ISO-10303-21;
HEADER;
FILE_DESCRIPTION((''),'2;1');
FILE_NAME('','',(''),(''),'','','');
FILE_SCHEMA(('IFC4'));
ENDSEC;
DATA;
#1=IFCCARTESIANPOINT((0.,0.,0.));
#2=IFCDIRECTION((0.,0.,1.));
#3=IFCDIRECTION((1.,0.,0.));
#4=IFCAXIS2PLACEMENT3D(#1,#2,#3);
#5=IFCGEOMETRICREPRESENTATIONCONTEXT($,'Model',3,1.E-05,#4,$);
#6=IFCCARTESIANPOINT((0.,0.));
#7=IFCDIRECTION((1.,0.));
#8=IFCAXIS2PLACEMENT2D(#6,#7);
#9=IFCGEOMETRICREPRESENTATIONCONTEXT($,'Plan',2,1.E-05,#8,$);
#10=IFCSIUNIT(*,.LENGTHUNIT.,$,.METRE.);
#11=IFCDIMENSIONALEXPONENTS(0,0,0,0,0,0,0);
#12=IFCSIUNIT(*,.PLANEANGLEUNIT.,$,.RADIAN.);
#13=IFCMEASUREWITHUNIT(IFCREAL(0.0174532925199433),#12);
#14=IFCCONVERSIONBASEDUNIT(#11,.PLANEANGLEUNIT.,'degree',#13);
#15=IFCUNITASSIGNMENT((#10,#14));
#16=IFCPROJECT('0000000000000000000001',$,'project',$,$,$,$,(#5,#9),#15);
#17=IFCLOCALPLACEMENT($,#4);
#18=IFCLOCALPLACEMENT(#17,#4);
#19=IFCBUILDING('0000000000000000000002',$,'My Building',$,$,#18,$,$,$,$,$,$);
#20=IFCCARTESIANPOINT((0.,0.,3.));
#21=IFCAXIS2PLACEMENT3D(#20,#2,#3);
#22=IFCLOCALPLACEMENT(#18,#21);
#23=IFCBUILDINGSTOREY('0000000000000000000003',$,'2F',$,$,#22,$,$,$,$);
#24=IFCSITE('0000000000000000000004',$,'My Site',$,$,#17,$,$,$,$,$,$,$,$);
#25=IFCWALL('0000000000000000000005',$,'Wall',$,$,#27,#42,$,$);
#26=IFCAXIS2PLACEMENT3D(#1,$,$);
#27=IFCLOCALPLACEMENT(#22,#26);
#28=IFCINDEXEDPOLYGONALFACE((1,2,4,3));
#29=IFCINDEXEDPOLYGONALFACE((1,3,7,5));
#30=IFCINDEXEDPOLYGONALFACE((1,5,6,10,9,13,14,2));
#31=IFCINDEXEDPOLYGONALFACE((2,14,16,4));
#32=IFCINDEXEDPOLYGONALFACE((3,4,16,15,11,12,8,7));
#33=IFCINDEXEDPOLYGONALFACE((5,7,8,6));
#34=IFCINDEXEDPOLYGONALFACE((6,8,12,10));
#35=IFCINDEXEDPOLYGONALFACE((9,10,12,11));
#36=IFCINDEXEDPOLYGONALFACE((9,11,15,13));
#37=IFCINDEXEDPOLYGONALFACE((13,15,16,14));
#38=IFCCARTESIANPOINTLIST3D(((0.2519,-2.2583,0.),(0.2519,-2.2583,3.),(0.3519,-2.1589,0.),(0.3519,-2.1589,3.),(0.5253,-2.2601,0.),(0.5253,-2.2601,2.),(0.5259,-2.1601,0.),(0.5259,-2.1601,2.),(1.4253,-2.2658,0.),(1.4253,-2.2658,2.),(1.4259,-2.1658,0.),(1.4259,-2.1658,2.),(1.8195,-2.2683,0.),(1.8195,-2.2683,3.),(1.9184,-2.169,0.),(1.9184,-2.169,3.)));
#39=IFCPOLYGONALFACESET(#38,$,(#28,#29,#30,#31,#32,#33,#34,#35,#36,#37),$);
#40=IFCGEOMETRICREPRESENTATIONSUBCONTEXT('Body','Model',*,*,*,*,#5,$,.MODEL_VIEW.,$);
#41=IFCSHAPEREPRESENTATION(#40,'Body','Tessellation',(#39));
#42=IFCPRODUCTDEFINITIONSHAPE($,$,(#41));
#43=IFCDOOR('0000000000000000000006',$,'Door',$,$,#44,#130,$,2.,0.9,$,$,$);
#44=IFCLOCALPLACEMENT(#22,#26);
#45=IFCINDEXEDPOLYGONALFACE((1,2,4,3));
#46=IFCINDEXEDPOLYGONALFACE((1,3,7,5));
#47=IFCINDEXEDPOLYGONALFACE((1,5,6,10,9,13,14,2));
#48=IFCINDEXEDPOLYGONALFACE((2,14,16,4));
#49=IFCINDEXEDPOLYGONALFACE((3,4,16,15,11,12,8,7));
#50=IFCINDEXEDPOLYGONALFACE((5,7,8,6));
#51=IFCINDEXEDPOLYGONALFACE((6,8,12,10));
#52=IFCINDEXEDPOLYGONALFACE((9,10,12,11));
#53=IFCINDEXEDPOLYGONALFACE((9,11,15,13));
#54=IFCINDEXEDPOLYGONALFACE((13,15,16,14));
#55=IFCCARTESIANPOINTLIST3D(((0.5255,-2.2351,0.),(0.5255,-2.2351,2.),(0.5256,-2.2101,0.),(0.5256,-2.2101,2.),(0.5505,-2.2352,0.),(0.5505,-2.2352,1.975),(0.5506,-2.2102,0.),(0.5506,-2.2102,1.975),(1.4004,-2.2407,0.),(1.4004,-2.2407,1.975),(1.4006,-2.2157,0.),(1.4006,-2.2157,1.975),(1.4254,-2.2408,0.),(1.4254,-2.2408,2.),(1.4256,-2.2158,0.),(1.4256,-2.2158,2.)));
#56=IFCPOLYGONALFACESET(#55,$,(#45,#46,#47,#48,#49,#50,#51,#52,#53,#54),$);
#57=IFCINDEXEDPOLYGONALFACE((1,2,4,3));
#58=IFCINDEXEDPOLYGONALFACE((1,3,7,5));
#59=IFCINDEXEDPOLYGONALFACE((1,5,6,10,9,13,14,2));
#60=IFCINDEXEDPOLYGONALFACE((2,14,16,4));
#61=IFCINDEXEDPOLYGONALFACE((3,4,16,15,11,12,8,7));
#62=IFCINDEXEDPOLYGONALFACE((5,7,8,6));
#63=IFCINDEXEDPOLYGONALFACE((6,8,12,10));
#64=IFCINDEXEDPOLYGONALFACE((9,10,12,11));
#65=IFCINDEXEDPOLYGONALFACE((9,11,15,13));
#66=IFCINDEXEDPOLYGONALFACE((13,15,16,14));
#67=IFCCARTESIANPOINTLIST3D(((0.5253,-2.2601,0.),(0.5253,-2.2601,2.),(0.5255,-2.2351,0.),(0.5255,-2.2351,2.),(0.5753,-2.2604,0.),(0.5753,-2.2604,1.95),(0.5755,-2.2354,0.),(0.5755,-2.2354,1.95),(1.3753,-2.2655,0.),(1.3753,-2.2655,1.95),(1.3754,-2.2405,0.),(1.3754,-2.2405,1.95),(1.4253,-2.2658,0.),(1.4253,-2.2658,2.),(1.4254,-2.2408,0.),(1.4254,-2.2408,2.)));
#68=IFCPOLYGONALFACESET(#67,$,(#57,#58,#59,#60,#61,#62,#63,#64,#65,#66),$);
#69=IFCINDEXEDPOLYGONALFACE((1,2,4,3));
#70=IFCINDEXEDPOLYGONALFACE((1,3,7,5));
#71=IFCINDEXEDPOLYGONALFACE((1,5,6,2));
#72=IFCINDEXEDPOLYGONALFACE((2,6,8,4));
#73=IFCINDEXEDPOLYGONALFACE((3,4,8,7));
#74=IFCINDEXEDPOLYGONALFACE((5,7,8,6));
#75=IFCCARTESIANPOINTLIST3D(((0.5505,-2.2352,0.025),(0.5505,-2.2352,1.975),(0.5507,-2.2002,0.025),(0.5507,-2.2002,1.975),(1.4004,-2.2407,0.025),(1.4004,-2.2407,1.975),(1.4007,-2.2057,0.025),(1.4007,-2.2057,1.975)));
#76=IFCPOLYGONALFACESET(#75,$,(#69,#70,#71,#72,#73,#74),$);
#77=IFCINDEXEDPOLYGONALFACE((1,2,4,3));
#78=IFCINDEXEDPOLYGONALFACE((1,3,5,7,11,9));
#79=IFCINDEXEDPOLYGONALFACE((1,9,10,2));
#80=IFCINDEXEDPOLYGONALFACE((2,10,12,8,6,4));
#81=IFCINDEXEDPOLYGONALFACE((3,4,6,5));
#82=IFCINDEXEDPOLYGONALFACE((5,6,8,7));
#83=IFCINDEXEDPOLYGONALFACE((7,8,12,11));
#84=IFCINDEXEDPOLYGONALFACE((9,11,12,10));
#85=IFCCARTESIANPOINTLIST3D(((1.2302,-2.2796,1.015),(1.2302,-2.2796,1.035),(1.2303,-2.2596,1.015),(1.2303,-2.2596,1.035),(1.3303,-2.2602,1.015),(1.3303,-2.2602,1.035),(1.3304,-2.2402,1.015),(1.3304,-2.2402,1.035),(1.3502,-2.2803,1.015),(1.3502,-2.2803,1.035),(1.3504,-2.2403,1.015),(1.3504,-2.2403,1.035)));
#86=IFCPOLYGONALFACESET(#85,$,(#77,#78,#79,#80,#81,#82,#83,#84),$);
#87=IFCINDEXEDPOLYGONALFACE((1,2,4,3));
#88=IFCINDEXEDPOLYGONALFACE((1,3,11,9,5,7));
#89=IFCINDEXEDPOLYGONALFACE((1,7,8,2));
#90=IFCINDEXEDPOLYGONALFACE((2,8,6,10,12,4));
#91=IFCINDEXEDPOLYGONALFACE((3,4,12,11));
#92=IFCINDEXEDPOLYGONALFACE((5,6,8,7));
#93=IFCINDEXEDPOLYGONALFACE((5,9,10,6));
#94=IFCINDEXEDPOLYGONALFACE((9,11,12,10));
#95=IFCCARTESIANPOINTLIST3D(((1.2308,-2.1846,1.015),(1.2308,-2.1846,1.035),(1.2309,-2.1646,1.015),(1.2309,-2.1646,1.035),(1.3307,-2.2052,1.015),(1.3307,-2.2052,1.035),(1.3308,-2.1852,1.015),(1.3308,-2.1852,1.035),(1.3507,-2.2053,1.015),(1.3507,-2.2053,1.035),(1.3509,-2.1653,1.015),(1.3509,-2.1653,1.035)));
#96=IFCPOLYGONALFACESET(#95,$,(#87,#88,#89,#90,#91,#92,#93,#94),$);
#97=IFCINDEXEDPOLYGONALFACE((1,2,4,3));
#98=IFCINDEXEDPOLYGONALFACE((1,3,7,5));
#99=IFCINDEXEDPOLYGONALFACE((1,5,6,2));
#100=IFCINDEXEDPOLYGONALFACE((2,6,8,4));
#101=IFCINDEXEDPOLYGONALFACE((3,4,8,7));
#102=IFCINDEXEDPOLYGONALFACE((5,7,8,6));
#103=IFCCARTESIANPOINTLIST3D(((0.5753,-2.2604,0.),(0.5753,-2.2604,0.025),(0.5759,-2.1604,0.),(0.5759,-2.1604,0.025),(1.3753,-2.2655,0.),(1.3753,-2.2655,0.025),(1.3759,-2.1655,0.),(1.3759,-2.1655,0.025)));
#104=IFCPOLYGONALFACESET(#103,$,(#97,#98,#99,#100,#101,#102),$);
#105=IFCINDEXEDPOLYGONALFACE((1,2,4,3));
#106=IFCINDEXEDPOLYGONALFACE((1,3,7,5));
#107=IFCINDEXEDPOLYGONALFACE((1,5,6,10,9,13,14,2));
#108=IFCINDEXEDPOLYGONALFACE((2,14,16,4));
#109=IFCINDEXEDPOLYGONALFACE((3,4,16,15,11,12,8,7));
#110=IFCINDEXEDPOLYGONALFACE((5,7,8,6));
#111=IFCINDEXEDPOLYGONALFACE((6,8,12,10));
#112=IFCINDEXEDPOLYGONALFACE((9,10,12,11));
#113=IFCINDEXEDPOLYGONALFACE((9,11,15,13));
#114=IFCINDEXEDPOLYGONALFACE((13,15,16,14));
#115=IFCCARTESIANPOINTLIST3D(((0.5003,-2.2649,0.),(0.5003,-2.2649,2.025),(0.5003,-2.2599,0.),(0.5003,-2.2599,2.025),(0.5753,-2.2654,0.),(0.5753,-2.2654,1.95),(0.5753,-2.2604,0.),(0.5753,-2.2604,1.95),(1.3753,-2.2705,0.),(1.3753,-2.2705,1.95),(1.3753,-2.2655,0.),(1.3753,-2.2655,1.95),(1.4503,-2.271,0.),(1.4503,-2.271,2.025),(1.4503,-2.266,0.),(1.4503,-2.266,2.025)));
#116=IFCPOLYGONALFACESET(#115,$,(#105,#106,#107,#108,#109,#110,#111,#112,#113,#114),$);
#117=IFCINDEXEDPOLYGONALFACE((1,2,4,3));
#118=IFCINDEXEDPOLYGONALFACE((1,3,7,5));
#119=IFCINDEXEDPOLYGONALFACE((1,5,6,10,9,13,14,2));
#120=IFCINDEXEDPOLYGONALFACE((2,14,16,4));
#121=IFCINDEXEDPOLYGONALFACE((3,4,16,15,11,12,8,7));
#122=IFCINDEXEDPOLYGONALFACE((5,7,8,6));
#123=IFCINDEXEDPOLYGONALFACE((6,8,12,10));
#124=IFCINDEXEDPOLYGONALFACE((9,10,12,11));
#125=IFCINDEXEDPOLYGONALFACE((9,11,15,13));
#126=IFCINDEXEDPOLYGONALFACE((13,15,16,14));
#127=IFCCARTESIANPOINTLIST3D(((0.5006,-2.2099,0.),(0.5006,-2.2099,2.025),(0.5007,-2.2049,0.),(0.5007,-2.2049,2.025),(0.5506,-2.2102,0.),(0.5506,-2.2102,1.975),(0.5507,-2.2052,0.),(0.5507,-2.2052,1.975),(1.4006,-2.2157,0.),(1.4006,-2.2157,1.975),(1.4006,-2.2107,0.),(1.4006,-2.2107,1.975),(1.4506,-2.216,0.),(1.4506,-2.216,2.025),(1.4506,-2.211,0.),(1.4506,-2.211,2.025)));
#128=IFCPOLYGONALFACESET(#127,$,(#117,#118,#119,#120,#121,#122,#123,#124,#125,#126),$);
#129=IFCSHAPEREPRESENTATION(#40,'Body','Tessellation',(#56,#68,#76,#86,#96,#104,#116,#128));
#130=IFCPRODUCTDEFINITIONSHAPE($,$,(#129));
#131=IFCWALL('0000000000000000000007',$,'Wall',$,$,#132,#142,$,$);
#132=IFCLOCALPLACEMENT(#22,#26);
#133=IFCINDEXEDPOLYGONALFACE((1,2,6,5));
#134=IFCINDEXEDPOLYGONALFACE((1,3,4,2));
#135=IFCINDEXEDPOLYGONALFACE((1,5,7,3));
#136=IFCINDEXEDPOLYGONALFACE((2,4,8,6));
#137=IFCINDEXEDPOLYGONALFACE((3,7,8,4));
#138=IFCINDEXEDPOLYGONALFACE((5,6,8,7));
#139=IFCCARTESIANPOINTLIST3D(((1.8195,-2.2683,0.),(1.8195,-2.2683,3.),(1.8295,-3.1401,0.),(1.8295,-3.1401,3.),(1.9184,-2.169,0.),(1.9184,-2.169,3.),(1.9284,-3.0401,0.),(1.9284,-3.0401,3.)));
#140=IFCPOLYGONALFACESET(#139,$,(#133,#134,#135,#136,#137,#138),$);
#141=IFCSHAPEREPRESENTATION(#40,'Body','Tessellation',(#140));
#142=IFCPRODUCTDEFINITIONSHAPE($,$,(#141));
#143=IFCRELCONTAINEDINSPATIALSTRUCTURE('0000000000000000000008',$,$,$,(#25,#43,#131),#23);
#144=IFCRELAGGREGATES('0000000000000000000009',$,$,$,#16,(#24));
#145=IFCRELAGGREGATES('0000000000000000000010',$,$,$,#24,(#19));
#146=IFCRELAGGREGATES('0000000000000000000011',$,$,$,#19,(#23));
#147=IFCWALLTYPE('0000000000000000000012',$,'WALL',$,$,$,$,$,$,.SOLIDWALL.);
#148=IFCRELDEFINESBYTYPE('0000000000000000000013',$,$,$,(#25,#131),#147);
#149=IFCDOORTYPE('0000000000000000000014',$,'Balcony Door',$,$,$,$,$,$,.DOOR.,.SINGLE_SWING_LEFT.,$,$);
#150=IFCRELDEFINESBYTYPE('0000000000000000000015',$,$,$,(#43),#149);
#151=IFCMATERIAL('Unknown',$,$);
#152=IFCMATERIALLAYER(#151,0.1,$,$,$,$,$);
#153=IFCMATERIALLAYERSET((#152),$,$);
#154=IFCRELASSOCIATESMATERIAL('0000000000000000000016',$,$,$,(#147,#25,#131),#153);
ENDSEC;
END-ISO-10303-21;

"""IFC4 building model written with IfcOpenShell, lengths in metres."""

from ifc_helpers import new_model, entity, si_unit, converted_unit, frame, origin_with_axes, origin_2d_with_axis, place, context, subcontext, project, spatial, line, indexed_curve, outline, extrude, shape, source, transform, mapped, material, layer, layer_set, layer_usage, type_object, type_shapes, element, fill, save


model = new_model("IFC4")

# Units and contexts
model_context = context("Model", 3, precision=1e-05, world=origin_with_axes())
plan_context = context("Plan", 2, precision=1e-05, world=origin_2d_with_axis())
body_context_1 = subcontext(model_context, "Body", "Model", "MODEL_VIEW")
body_context_2 = subcontext(plan_context, "Body", "Plan", "PLAN_VIEW")
ifc_project = project(units=[si_unit("LENGTHUNIT", "METRE"), converted_unit("PLANEANGLEUNIT", "degree", entity("IfcReal", 0.0174532925199433), si_unit("PLANEANGLEUNIT", "RADIAN"), dimensions=[0, 0, 0, 0, 0, 0, 0])], contexts=[model_context, plan_context])

# Site, building, storey
site_placement = place(None, origin_with_axes())
site = spatial("IfcSite", under=ifc_project, at=site_placement, Name="My Site")
building_placement = place(site_placement, origin_with_axes())
building = spatial("IfcBuilding", under=site, at=building_placement, Name="My Building")
storey_placement = place(building_placement, frame((0.0, 0.0, 3.0), z_axis=(0.0, 0.0, 1.0), x_axis=(1.0, 0.0, 0.0)))
storey = spatial("IfcBuildingStorey", under=building, at=storey_placement, Name="2F")

# Shared definitions
ifc_material = material(Name="Unknown")

# Shared definitions
ifc_layer_1 = layer(ifc_material, 0.1)
ifc_layer_set_1 = layer_set([ifc_layer_1])
wall_type = type_object("IfcWallType", Name="WALL", PredefinedType="SOLIDWALL", material=ifc_layer_set_1)

# Wall, opening, door
ifc_layer_usage_1 = layer_usage(ifc_layer_set_1, "AXIS2", "POSITIVE", 0.0)
wall_1_placement = place(storey_placement, frame((0.2519, -2.2583, 0.0), z_axis=(0.0, 0.0, 1.0), x_axis=(0.999979, -0.00641, 0.0)))
wall_1 = element("IfcWall", 1, at=wall_1_placement, inside=storey, type_object=wall_type, material=ifc_layer_usage_1, Name="Wall", context=body_context_1, shape_type="SweptSolid", body=[
    extrude(outline(indexed_curve([(0.0, 0.0), (0.0994, 0.1), (1.6659, 0.1), (1.5676, 0.0)], segments=[line(1, 2, 3, 4, 1)])), origin_with_axes(), (0.0, 0.0, 1.0), 3.0),
])
shared_shape_1 = source(origin_with_axes(), body_context_1, "Body", "SweptSolid", [
    extrude(outline(indexed_curve([(0.0, 0.0), (0.9, 0.0), (0.9, 2.0), (0.0, 2.0)], segments=[line(1, 2, 3, 4, 1)])), frame((0.0, -0.6, 0.0), z_axis=(0.0, -1.0, 0.0), x_axis=(1.0, 0.0, 0.0)), (0.0, 0.0, -1.0), 1.2),
])
opening_1_placement = place(wall_1_placement, frame((0.2734, 0.0, 0.0), z_axis=(0.0, 0.0, 1.0), x_axis=(1.0, 0.0, 0.0)))
opening_1 = element("IfcOpeningElement", 2, at=opening_1_placement, cuts=wall_1, PredefinedType="OPENING", context=body_context_1, shape_type="MappedRepresentation", body=[
    mapped(shared_shape_1, transform((0.0, 0.0, 0.0), x_axis=(1.0, 0.0, 0.0), y_axis=(0.0, 1.0, 0.0), z_axis=(0.0, 0.0, 1.0), scale=1.0)),
])
door_type = type_object("IfcDoorType", Name="Balcony Door", OperationType="SINGLE_SWING_LEFT", PredefinedType="DOOR")
shared_shape_2 = source(origin_with_axes(), body_context_1, "Body", "SweptSolid", [
    extrude(outline(indexed_curve([(0.0, 0.0), (0.0, 2.0), (0.9, 2.0), (0.9, 0.0), (0.875, 0.0), (0.875, 1.975), (0.025, 1.975), (0.025, 0.0)], segments=[line(1, 2, 3, 4, 5, 6, 7, 8, 1)])), frame((0.0, 0.025, 0.0), z_axis=(0.0, -1.0, 0.0), x_axis=(1.0, 0.0, 0.0)), (0.0, 0.0, -1.0), 0.025),
    extrude(outline(indexed_curve([(0.0, 0.0), (0.0, 2.0), (0.9, 2.0), (0.9, 0.0), (0.85, 0.0), (0.85, 1.95), (0.05, 1.95), (0.05, 0.0)], segments=[line(1, 2, 3, 4, 5, 6, 7, 8, 1)])), frame((0.0, 0.0, 0.0), z_axis=(0.0, -1.0, 0.0), x_axis=(1.0, 0.0, 0.0)), (0.0, 0.0, -1.0), 0.025),
    extrude(outline(indexed_curve([(0.0, 0.0), (0.85, 0.0), (0.85, 0.035), (0.0, 0.035)], segments=[line(1, 2, 3, 4, 1)])), frame((0.025, 0.025, 0.025), z_axis=(0.0, 0.0, 1.0), x_axis=(1.0, 0.0, 0.0)), (0.0, 0.0, 1.0), 1.95),
    extrude(outline(indexed_curve([(0.0, 0.0), (0.0, -0.04), (-0.12, -0.04), (-0.12, -0.02), (-0.02, -0.02), (-0.02, 0.0)], segments=[line(1, 2, 3, 4, 5, 6, 1)])), frame((0.825, 0.025, 1.015), z_axis=(0.0, 0.0, 1.0), x_axis=(1.0, 0.0, 0.0)), (0.0, 0.0, 1.0), 0.02),
    extrude(outline(indexed_curve([(0.0, 0.0), (0.0, 0.04), (-0.12, 0.04), (-0.12, 0.02), (-0.02, 0.02), (-0.02, 0.0)], segments=[line(1, 2, 3, 4, 5, 6, 1)])), frame((0.825, 0.06, 1.015), z_axis=(0.0, 0.0, 1.0), x_axis=(1.0, 0.0, 0.0)), (0.0, 0.0, 1.0), 0.02),
    extrude(outline(indexed_curve([(0.0, 0.0), (0.8, 0.0), (0.8, 0.1), (0.0, 0.1)], segments=[line(1, 2, 3, 4, 1)])), frame((0.05, 0.0, 0.0), z_axis=(0.0, 0.0, 1.0), x_axis=(1.0, 0.0, 0.0)), (0.0, 0.0, 1.0), 0.025),
    extrude(outline(indexed_curve([(0.0, 0.0), (0.0, 2.025), (0.95, 2.025), (0.95, 0.0), (0.875, 0.0), (0.875, 1.95), (0.075, 1.95), (0.075, 0.0)], segments=[line(1, 2, 3, 4, 5, 6, 7, 8, 1)])), frame((-0.025, -0.005, 0.0), z_axis=(0.0, -1.0, 0.0), x_axis=(1.0, 0.0, 0.0)), (0.0, 0.0, -1.0), 0.005),
    extrude(outline(indexed_curve([(0.0, 0.0), (0.0, 2.025), (0.95, 2.025), (0.95, 0.0), (0.9, 0.0), (0.9, 1.975), (0.05, 1.975), (0.05, 0.0)], segments=[line(1, 2, 3, 4, 5, 6, 7, 8, 1)])), frame((-0.025, 0.05, 0.0), z_axis=(0.0, -1.0, 0.0), x_axis=(1.0, 0.0, 0.0)), (0.0, 0.0, -1.0), 0.005),
])
shared_shape_3 = source(origin_with_axes(), body_context_2, "Body", "Curve2D", [
    entity("IfcIndexedPolyCurve", entity("IfcCartesianPointList2D", [[0.0, 0.0], [0.0, 0.05], [0.025, 0.05], [0.025, 0.025], [0.05, 0.025], [0.05, 0.0]]), [entity("IfcLineIndex", [1, 2, 3, 4, 5, 6, 1])]),
    entity("IfcIndexedPolyCurve", entity("IfcCartesianPointList2D", [[0.9, 0.0], [0.9, 0.05], [0.875, 0.05], [0.875, 0.025], [0.85, 0.025], [0.85, 0.0]]), [entity("IfcLineIndex", [1, 2, 3, 4, 5, 6, 1])]),
    entity("IfcTrimmedCurve", entity("IfcEllipse", entity("IfcAxis2Placement2D", entity("IfcCartesianPoint", [0.06, 0.05]), entity("IfcDirection", [1.0, 0.0])), 0.815, 0.85), [entity("IfcCartesianPoint", [0.875, 0.05])], [entity("IfcCartesianPoint", [0.06, 0.9])], True, "CARTESIAN"),
    entity("IfcIndexedPolyCurve", entity("IfcCartesianPointList2D", [[0.025, 0.05], [0.06, 0.05], [0.06, 0.9], [0.025, 0.9]]), [entity("IfcLineIndex", [1, 2, 3, 4, 1])]),
])
type_shapes(door_type, [shared_shape_2, shared_shape_3])
door_placement = place(opening_1_placement, frame((0.0, 0.0, 0.0), z_axis=(0.0, 0.0, 1.0), x_axis=(1.0, 0.0, 0.0)))
door = element("IfcDoor", 3, at=door_placement, inside=storey, type_object=door_type, Name="Door", OverallHeight=2.0, OverallWidth=0.9, shapes=[
    shape(body_context_1, "Body", "MappedRepresentation", [mapped(shared_shape_2, transform((0.0, 0.0, 0.0), x_axis=(1.0, 0.0, 0.0), y_axis=(0.0, 1.0, 0.0), z_axis=(0.0, 0.0, 1.0), scale=1.0))]),
    shape(body_context_2, "Body", "MappedRepresentation", [mapped(shared_shape_3, transform((0.0, 0.0, 0.0), x_axis=(1.0, 0.0, 0.0), y_axis=(0.0, 1.0, 0.0), z_axis=(0.0, 0.0, 1.0), scale=1.0))]),
])
fill(opening_1, door)

# Wall
ifc_layer_usage_2 = layer_usage(ifc_layer_set_1, "AXIS2", "POSITIVE", 0.0)
wall_2_placement = place(storey_placement, frame((1.8195, -2.2683, 0.0), z_axis=(0.0, 0.0, 1.0), x_axis=(0.011526, -0.999934, 0.0)))
element("IfcWall", 4, at=wall_2_placement, inside=storey, type_object=wall_type, material=ifc_layer_usage_2, Name="Wall", context=body_context_1, shape_type="SweptSolid", body=[
    extrude(outline(indexed_curve([(0.0, 0.0), (-0.0982, 0.1), (0.773, 0.1), (0.8718, 0.0)], segments=[line(1, 2, 3, 4, 1)])), origin_with_axes(), (0.0, 0.0, 1.0), 3.0),
])

save(model, "model.ifc")
